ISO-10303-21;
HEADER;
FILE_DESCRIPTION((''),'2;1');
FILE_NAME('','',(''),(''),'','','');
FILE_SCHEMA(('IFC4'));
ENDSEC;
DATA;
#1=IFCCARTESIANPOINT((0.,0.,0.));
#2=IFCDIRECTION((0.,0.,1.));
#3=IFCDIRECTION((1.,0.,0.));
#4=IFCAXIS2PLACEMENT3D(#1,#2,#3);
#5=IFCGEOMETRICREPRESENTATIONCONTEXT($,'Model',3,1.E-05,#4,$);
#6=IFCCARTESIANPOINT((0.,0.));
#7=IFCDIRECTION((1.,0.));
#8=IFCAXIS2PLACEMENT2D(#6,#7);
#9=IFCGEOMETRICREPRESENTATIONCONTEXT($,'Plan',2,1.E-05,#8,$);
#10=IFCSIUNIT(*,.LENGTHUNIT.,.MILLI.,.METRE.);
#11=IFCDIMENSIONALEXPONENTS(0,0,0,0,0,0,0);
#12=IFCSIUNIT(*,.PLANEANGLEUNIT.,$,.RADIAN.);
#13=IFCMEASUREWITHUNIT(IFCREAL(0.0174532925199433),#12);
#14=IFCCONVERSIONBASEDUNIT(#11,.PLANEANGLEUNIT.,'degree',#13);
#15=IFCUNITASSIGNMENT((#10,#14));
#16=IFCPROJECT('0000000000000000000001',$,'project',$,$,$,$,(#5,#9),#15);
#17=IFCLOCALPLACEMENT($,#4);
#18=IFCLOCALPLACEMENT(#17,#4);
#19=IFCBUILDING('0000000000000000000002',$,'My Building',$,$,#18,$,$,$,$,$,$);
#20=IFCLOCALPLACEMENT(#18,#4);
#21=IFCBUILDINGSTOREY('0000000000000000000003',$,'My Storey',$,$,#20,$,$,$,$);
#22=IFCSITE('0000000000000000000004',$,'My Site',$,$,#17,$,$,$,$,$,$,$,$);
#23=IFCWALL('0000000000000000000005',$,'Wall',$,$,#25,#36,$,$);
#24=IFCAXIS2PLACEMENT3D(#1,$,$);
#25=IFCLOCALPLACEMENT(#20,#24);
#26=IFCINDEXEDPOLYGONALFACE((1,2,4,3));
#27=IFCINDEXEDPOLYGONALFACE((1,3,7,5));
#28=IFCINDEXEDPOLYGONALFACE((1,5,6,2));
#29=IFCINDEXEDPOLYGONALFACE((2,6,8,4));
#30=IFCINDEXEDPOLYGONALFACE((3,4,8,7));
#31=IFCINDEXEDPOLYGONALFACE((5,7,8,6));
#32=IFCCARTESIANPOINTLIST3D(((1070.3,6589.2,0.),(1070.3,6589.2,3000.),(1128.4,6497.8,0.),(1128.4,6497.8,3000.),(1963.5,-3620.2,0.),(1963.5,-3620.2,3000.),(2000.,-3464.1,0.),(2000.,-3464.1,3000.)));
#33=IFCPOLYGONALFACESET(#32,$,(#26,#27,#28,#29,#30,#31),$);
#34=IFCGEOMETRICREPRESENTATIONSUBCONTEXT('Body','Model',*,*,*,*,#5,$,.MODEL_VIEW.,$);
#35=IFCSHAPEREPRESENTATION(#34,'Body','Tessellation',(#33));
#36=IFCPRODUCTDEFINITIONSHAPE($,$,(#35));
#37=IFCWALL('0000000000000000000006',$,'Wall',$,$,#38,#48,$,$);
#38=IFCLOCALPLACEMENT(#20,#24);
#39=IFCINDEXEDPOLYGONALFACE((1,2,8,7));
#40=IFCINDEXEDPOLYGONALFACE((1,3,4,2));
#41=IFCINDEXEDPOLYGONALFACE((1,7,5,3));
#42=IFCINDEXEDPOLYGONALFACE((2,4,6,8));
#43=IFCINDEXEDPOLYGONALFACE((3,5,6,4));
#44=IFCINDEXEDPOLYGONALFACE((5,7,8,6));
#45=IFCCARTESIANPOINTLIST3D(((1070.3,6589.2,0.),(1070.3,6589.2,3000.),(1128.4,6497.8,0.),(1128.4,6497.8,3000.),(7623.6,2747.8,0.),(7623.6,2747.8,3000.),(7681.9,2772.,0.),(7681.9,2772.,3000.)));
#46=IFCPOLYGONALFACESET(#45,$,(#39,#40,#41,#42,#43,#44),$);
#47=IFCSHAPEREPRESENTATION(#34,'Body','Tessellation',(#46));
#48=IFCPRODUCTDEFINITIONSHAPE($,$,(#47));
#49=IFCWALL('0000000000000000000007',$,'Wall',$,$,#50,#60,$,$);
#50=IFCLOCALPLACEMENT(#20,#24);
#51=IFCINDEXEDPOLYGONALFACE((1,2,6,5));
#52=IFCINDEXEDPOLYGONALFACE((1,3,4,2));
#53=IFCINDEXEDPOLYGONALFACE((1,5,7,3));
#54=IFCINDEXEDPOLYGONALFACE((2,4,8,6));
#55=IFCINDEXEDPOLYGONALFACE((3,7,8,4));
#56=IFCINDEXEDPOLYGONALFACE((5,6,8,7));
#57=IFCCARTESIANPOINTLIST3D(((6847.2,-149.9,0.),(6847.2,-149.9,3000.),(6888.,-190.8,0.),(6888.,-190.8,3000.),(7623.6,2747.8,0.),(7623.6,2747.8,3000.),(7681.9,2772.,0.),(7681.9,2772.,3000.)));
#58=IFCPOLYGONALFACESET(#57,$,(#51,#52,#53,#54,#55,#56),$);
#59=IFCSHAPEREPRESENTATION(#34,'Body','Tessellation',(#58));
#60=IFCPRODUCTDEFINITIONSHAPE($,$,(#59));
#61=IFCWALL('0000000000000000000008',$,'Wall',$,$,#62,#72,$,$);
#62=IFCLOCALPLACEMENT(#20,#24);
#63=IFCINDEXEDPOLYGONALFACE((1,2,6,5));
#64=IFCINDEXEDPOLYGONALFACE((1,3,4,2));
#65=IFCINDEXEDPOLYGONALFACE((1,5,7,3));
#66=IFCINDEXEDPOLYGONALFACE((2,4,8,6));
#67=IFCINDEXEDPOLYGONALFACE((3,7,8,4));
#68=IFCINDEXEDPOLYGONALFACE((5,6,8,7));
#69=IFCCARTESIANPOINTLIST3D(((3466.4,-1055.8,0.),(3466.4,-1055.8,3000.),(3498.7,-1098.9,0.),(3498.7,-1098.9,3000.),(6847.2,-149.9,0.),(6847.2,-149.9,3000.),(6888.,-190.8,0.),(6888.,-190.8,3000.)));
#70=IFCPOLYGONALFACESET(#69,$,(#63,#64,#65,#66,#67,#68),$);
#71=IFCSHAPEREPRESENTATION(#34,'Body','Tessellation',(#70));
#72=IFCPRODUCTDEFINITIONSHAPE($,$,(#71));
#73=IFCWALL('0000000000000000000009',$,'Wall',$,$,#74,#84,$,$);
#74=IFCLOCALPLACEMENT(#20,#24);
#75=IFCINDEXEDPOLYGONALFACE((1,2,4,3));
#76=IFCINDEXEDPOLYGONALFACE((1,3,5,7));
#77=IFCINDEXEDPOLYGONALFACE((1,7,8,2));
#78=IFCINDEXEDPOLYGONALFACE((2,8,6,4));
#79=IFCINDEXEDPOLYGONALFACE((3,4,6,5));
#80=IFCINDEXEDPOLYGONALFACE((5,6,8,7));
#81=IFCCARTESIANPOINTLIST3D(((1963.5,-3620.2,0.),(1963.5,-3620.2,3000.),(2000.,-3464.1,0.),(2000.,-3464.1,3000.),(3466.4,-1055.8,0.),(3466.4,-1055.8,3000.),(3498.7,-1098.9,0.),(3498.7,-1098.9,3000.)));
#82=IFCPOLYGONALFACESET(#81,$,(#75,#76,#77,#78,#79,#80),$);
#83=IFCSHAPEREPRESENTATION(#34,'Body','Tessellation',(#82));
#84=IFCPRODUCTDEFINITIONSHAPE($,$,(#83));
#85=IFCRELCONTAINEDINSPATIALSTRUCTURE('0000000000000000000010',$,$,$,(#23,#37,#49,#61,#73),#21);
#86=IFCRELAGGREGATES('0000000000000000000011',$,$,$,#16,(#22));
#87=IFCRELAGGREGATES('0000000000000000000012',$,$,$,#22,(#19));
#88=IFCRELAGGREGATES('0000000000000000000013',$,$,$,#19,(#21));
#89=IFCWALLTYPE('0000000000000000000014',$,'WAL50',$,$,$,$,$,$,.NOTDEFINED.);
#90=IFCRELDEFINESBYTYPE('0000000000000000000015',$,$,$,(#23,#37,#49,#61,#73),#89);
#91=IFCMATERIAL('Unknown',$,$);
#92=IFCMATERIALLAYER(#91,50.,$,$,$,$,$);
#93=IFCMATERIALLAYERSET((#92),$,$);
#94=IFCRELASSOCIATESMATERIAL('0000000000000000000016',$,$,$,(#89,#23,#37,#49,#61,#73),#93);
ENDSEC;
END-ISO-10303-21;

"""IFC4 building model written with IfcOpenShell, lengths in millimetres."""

from ifc_helpers import new_model, entity, si_unit, converted_unit, frame, origin_with_axes, origin_2d_with_axis, place, context, subcontext, project, spatial, line, indexed_curve, outline, extrude, material, layer, layer_set, layer_usage, type_object, element, save


model = new_model("IFC4")

# Units and contexts
model_context = context("Model", 3, precision=1e-05, world=origin_with_axes())
plan_context = context("Plan", 2, precision=1e-05, world=origin_2d_with_axis())
body_context = subcontext(model_context, "Body", "Model", "MODEL_VIEW")
ifc_project = project(units=[si_unit("LENGTHUNIT", "METRE", prefix="MILLI"), converted_unit("PLANEANGLEUNIT", "degree", entity("IfcReal", 0.0174532925199433), si_unit("PLANEANGLEUNIT", "RADIAN"), dimensions=[0, 0, 0, 0, 0, 0, 0])], contexts=[model_context, plan_context])

# Site, building, storey
site_placement = place(None, origin_with_axes())
site = spatial("IfcSite", under=ifc_project, at=site_placement, Name="My Site")
building_placement = place(site_placement, origin_with_axes())
building = spatial("IfcBuilding", under=site, at=building_placement, Name="My Building")
storey_placement = place(building_placement, origin_with_axes())
storey = spatial("IfcBuildingStorey", under=building, at=storey_placement, Name="My Storey")

# Walls
ifc_material = material(Name="Unknown")
ifc_layer = layer(ifc_material, 50.0)
ifc_layer_set = layer_set([ifc_layer])
ifc_layer_usage_1 = layer_usage(ifc_layer_set, "AXIS2", "POSITIVE", 0.0)
wall_type = type_object("IfcWallType", Name="WAL50", PredefinedType="NOTDEFINED", material=ifc_layer_set)
wall_1_placement = place(storey_placement, frame((2000.0, -3464.1, 0.0), z_axis=(0.0, 0.0, 1.0), x_axis=(-0.087156, 0.996195, 0.0)))
element("IfcWall", 1, at=wall_1_placement, inside=storey, type_object=wall_type, material=ifc_layer_usage_1, Name="Wall", context=body_context, shape_type="SweptSolid", body=[
    extrude(outline(indexed_curve([(0.0, 0.0), (-152.4, 50.0), (10096.0, 50.0), (10000.0, 0.0)], segments=[line(1, 2, 3, 4, 1)])), origin_with_axes(), (0.0, 0.0, 1.0), 3000.0),
])
ifc_layer_usage_2 = layer_usage(ifc_layer_set, "AXIS2", "POSITIVE", 0.0)
wall_2_placement = place(storey_placement, frame((1128.4, 6497.8, 0.0), z_axis=(0.0, 0.0, 1.0), x_axis=(0.866025, -0.5, 0.0)))
element("IfcWall", 2, at=wall_2_placement, inside=storey, type_object=wall_type, material=ifc_layer_usage_2, Name="Wall", context=body_context, shape_type="SweptSolid", body=[
    extrude(outline(indexed_curve([(0.0, 0.0), (-96.0, 50.0), (7538.4, 50.0), (7500.0, 0.0)], segments=[line(1, 2, 3, 4, 1)])), origin_with_axes(), (0.0, 0.0, 1.0), 3000.0),
])
ifc_layer_usage_3 = layer_usage(ifc_layer_set, "AXIS2", "POSITIVE", 0.0)
wall_3_placement = place(storey_placement, frame((7623.6, 2747.8, 0.0), z_axis=(0.0, 0.0, 1.0), x_axis=(-0.258819, -0.965926, 0.0)))
element("IfcWall", 3, at=wall_3_placement, inside=storey, type_object=wall_type, material=ifc_layer_usage_3, Name="Wall", context=body_context, shape_type="SweptSolid", body=[
    extrude(outline(indexed_curve([(0.0, 0.0), (-38.4, 50.0), (3028.9, 50.0), (3000.0, 0.0)], segments=[line(1, 2, 3, 4, 1)])), origin_with_axes(), (0.0, 0.0, 1.0), 3000.0),
])
ifc_layer_usage_4 = layer_usage(ifc_layer_set, "AXIS2", "POSITIVE", 0.0)
wall_4_placement = place(storey_placement, frame((6847.2, -149.9, 0.0), z_axis=(0.0, 0.0, 1.0), x_axis=(-0.965926, -0.258818, 0.0)))
element("IfcWall", 4, at=wall_4_placement, inside=storey, type_object=wall_type, material=ifc_layer_usage_4, Name="Wall", context=body_context, shape_type="SweptSolid", body=[
    extrude(outline(indexed_curve([(0.0, 0.0), (-28.9, 50.0), (3480.0, 50.0), (3500.0, 0.0)], segments=[line(1, 2, 3, 4, 1)])), origin_with_axes(), (0.0, 0.0, 1.0), 3000.0),
])
ifc_layer_usage_5 = layer_usage(ifc_layer_set, "AXIS2", "POSITIVE", 0.0)
wall_5_placement = place(storey_placement, frame((3466.4, -1055.8, 0.0), z_axis=(0.0, 0.0, 1.0), x_axis=(-0.520079, -0.854118, 0.0)))
element("IfcWall", 5, at=wall_5_placement, inside=storey, type_object=wall_type, material=ifc_layer_usage_5, Name="Wall", context=body_context, shape_type="SweptSolid", body=[
    extrude(outline(indexed_curve([(0.0, 0.0), (20.0, 50.0), (2972.0, 50.0), (2819.6, 0.0)], segments=[line(1, 2, 3, 4, 1)])), origin_with_axes(), (0.0, 0.0, 1.0), 3000.0),
])

save(model, "model.ifc")
